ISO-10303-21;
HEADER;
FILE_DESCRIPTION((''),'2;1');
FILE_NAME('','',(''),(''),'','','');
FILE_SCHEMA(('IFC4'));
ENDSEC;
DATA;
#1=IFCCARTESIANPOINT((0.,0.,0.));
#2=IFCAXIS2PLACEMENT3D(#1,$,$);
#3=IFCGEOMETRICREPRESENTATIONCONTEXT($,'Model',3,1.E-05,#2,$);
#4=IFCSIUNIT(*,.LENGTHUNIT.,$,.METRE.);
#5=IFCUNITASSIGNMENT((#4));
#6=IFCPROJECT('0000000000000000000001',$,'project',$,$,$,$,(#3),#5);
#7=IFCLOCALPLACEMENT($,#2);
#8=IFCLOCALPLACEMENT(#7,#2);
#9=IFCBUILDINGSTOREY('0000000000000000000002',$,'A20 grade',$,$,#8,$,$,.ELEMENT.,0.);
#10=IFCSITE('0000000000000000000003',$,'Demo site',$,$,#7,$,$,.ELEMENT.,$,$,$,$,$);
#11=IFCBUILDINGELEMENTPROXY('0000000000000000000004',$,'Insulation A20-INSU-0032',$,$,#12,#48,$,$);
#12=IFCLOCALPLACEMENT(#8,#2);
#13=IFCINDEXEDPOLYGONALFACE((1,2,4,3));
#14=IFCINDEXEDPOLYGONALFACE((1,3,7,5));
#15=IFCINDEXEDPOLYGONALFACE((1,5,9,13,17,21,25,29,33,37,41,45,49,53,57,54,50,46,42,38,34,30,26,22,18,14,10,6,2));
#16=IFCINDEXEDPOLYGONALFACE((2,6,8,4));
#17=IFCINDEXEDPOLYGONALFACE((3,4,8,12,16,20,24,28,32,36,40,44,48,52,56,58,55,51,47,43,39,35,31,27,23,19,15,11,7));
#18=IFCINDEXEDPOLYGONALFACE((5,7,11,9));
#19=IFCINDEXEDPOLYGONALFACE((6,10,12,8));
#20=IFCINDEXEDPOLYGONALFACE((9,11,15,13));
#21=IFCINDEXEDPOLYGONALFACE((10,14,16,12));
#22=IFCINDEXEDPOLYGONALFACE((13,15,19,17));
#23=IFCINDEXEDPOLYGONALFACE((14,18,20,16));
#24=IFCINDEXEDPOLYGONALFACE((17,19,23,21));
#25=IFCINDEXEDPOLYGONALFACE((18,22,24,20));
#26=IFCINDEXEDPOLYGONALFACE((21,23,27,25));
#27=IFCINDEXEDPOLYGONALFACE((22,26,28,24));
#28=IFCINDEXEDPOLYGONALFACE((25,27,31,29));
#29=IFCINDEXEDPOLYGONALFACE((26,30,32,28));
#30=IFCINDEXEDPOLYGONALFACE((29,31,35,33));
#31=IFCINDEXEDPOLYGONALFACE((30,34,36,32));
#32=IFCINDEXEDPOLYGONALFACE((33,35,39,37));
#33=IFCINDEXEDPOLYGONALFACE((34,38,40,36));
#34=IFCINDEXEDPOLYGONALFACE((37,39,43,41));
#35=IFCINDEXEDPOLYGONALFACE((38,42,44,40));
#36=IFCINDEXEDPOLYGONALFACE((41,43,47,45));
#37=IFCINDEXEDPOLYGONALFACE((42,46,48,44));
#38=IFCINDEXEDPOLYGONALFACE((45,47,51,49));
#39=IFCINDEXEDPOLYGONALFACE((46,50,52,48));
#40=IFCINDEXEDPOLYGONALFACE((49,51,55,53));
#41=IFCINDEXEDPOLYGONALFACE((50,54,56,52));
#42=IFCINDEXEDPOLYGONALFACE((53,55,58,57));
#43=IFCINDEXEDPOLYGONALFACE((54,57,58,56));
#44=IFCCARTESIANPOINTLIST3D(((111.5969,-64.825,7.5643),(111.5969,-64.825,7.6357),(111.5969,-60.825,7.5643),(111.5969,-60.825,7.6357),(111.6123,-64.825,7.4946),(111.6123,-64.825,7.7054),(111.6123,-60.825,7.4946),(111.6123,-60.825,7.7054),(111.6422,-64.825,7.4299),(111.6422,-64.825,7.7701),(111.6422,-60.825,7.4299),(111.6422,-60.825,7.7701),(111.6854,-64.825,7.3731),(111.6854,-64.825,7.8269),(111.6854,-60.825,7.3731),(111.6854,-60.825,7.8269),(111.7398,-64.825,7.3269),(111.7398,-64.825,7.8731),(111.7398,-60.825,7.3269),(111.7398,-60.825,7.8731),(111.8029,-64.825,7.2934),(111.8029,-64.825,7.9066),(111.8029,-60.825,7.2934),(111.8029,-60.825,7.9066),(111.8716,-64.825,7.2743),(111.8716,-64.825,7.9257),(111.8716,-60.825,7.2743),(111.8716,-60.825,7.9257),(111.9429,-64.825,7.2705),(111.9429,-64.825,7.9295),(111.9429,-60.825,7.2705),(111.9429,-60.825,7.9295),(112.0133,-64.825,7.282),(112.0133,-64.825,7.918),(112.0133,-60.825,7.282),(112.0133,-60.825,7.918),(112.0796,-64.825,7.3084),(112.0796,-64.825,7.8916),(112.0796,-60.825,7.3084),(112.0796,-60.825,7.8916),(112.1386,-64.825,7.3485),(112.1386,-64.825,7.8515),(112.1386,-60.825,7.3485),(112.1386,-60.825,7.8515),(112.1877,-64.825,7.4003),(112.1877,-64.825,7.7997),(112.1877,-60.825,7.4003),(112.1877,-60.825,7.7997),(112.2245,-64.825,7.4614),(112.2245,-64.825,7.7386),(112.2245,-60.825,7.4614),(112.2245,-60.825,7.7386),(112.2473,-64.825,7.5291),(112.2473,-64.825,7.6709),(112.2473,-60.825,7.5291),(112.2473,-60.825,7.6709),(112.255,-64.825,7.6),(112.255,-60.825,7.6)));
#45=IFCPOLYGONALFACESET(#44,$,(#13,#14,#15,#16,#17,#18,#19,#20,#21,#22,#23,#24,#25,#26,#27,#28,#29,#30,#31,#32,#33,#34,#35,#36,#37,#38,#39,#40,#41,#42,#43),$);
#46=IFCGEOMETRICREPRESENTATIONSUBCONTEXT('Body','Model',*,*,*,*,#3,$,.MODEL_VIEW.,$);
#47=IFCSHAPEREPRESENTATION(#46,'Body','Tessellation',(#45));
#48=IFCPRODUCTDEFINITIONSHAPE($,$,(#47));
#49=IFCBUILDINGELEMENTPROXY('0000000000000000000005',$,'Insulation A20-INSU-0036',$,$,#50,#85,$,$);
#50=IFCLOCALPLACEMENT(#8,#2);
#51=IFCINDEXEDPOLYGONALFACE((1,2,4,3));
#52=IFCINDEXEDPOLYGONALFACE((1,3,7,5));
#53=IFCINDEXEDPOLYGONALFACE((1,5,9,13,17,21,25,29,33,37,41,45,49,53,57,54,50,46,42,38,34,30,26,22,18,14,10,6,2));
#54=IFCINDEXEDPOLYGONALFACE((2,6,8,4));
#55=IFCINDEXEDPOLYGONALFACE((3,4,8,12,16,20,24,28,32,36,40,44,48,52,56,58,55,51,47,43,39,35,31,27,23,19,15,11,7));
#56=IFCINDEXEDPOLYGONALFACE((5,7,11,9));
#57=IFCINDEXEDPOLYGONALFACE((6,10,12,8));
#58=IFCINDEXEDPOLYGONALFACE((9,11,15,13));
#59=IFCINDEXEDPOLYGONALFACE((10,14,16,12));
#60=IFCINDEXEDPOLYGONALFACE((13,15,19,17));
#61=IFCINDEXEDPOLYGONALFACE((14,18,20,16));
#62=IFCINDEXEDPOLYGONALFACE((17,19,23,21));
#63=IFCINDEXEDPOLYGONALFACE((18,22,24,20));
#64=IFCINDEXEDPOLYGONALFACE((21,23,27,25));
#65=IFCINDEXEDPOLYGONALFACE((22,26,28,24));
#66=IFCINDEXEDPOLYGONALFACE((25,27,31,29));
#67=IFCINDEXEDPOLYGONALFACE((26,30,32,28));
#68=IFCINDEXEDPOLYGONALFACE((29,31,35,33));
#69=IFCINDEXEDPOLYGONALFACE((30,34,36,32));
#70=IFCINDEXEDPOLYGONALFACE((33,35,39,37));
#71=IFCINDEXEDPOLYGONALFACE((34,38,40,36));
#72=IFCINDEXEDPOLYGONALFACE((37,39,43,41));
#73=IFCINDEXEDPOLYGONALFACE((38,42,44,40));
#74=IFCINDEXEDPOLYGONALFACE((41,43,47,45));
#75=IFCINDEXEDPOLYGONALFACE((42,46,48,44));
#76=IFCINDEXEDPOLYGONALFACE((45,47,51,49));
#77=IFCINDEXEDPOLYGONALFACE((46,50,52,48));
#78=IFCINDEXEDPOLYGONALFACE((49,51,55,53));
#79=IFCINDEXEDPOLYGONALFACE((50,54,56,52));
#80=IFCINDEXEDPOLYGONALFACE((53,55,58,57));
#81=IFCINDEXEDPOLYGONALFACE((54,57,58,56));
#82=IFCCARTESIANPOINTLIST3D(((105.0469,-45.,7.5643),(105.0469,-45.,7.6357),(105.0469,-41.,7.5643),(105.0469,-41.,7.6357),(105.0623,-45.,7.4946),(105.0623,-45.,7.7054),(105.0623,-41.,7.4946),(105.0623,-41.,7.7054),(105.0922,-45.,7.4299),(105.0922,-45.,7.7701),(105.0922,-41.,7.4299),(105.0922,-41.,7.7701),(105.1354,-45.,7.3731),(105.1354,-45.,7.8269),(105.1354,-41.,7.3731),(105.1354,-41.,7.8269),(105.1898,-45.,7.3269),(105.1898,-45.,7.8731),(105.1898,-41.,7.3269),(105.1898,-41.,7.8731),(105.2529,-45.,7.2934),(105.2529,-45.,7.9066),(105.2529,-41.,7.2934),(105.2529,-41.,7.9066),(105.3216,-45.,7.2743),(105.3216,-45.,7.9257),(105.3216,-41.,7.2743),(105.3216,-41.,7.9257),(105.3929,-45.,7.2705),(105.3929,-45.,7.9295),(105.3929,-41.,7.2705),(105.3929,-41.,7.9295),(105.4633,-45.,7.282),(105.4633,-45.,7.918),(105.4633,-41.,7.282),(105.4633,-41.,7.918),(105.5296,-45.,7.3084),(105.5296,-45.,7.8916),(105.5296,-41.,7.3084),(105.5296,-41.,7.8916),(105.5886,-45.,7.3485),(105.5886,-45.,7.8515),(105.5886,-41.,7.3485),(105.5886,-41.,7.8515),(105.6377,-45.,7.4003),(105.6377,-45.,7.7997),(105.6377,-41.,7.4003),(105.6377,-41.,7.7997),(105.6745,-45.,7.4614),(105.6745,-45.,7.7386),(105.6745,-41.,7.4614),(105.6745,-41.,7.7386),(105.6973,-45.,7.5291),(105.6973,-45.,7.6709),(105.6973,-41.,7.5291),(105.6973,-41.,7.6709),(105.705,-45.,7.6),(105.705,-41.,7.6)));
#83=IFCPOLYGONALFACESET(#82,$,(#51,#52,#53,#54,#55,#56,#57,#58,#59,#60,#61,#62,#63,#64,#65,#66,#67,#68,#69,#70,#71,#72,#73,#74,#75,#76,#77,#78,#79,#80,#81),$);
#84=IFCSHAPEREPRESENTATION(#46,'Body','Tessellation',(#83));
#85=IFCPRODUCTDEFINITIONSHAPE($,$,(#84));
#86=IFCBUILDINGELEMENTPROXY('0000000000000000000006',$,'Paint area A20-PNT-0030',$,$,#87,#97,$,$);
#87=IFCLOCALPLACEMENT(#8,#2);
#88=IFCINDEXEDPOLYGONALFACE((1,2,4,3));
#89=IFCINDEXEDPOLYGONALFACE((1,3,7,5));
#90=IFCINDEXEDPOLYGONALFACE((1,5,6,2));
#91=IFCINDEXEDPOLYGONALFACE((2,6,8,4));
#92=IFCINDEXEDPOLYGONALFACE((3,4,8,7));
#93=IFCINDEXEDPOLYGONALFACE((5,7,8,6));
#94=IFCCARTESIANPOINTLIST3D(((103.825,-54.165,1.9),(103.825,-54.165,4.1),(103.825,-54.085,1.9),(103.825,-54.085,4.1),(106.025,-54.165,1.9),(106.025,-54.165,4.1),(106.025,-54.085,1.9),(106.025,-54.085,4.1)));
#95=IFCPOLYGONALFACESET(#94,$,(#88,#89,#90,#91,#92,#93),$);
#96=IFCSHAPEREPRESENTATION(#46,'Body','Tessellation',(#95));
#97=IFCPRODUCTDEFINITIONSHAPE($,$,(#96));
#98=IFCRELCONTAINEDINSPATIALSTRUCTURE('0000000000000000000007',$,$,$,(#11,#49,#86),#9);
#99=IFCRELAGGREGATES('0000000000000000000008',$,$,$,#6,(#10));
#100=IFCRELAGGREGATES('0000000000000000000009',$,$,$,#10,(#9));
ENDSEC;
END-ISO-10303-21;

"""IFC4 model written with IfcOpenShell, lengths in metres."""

from ifc_helpers import new_model, si_unit, frame, origin, place, context, subcontext, project, spatial, rectangle, circle, extrude, element, save


model = new_model("IFC4")

# Units and contexts
model_context = context("Model", 3, precision=1e-05, world=origin())
body_context = subcontext(model_context, "Body", "Model", "MODEL_VIEW")
ifc_project = project(units=[si_unit("LENGTHUNIT", "METRE")], contexts=[model_context])

# Site, storey
site_placement = place(None, origin())
site = spatial("IfcSite", under=ifc_project, at=site_placement, Name="Demo site", CompositionType="ELEMENT")
storey_placement = place(site_placement, origin())
storey = spatial("IfcBuildingStorey", under=site, at=storey_placement, Name="A20 grade", CompositionType="ELEMENT", Elevation=0.0)

# Building element proxies
for number, where, name in (
    (1, (111.925, -64.825, 7.6), "Insulation A20-INSU-0032"),
    (2, (105.375, -45.0, 7.6), "Insulation A20-INSU-0036"),
):
    element("IfcBuildingElementProxy", number, at=place(storey_placement, frame(where)), inside=storey, Name=name, context=body_context, shape_type="SweptSolid", body=[
        extrude(circle(Radius=0.33), frame((0.0, 0.0, 0.0), z_axis=(0.0, 1.0, 0.0), x_axis=(1.0, 0.0, 0.0)), (0.0, 0.0, 1.0), 4.0),
    ])
proxy_placement = place(storey_placement, frame((104.925, -54.125, 1.9)))
element("IfcBuildingElementProxy", 3, at=proxy_placement, inside=storey, Name="Paint area A20-PNT-0030", context=body_context, shape_type="SweptSolid", body=[
    extrude(rectangle(XDim=2.2, YDim=0.08), origin(), (0.0, 0.0, 1.0), 2.2),
])

save(model, "model.ifc")
